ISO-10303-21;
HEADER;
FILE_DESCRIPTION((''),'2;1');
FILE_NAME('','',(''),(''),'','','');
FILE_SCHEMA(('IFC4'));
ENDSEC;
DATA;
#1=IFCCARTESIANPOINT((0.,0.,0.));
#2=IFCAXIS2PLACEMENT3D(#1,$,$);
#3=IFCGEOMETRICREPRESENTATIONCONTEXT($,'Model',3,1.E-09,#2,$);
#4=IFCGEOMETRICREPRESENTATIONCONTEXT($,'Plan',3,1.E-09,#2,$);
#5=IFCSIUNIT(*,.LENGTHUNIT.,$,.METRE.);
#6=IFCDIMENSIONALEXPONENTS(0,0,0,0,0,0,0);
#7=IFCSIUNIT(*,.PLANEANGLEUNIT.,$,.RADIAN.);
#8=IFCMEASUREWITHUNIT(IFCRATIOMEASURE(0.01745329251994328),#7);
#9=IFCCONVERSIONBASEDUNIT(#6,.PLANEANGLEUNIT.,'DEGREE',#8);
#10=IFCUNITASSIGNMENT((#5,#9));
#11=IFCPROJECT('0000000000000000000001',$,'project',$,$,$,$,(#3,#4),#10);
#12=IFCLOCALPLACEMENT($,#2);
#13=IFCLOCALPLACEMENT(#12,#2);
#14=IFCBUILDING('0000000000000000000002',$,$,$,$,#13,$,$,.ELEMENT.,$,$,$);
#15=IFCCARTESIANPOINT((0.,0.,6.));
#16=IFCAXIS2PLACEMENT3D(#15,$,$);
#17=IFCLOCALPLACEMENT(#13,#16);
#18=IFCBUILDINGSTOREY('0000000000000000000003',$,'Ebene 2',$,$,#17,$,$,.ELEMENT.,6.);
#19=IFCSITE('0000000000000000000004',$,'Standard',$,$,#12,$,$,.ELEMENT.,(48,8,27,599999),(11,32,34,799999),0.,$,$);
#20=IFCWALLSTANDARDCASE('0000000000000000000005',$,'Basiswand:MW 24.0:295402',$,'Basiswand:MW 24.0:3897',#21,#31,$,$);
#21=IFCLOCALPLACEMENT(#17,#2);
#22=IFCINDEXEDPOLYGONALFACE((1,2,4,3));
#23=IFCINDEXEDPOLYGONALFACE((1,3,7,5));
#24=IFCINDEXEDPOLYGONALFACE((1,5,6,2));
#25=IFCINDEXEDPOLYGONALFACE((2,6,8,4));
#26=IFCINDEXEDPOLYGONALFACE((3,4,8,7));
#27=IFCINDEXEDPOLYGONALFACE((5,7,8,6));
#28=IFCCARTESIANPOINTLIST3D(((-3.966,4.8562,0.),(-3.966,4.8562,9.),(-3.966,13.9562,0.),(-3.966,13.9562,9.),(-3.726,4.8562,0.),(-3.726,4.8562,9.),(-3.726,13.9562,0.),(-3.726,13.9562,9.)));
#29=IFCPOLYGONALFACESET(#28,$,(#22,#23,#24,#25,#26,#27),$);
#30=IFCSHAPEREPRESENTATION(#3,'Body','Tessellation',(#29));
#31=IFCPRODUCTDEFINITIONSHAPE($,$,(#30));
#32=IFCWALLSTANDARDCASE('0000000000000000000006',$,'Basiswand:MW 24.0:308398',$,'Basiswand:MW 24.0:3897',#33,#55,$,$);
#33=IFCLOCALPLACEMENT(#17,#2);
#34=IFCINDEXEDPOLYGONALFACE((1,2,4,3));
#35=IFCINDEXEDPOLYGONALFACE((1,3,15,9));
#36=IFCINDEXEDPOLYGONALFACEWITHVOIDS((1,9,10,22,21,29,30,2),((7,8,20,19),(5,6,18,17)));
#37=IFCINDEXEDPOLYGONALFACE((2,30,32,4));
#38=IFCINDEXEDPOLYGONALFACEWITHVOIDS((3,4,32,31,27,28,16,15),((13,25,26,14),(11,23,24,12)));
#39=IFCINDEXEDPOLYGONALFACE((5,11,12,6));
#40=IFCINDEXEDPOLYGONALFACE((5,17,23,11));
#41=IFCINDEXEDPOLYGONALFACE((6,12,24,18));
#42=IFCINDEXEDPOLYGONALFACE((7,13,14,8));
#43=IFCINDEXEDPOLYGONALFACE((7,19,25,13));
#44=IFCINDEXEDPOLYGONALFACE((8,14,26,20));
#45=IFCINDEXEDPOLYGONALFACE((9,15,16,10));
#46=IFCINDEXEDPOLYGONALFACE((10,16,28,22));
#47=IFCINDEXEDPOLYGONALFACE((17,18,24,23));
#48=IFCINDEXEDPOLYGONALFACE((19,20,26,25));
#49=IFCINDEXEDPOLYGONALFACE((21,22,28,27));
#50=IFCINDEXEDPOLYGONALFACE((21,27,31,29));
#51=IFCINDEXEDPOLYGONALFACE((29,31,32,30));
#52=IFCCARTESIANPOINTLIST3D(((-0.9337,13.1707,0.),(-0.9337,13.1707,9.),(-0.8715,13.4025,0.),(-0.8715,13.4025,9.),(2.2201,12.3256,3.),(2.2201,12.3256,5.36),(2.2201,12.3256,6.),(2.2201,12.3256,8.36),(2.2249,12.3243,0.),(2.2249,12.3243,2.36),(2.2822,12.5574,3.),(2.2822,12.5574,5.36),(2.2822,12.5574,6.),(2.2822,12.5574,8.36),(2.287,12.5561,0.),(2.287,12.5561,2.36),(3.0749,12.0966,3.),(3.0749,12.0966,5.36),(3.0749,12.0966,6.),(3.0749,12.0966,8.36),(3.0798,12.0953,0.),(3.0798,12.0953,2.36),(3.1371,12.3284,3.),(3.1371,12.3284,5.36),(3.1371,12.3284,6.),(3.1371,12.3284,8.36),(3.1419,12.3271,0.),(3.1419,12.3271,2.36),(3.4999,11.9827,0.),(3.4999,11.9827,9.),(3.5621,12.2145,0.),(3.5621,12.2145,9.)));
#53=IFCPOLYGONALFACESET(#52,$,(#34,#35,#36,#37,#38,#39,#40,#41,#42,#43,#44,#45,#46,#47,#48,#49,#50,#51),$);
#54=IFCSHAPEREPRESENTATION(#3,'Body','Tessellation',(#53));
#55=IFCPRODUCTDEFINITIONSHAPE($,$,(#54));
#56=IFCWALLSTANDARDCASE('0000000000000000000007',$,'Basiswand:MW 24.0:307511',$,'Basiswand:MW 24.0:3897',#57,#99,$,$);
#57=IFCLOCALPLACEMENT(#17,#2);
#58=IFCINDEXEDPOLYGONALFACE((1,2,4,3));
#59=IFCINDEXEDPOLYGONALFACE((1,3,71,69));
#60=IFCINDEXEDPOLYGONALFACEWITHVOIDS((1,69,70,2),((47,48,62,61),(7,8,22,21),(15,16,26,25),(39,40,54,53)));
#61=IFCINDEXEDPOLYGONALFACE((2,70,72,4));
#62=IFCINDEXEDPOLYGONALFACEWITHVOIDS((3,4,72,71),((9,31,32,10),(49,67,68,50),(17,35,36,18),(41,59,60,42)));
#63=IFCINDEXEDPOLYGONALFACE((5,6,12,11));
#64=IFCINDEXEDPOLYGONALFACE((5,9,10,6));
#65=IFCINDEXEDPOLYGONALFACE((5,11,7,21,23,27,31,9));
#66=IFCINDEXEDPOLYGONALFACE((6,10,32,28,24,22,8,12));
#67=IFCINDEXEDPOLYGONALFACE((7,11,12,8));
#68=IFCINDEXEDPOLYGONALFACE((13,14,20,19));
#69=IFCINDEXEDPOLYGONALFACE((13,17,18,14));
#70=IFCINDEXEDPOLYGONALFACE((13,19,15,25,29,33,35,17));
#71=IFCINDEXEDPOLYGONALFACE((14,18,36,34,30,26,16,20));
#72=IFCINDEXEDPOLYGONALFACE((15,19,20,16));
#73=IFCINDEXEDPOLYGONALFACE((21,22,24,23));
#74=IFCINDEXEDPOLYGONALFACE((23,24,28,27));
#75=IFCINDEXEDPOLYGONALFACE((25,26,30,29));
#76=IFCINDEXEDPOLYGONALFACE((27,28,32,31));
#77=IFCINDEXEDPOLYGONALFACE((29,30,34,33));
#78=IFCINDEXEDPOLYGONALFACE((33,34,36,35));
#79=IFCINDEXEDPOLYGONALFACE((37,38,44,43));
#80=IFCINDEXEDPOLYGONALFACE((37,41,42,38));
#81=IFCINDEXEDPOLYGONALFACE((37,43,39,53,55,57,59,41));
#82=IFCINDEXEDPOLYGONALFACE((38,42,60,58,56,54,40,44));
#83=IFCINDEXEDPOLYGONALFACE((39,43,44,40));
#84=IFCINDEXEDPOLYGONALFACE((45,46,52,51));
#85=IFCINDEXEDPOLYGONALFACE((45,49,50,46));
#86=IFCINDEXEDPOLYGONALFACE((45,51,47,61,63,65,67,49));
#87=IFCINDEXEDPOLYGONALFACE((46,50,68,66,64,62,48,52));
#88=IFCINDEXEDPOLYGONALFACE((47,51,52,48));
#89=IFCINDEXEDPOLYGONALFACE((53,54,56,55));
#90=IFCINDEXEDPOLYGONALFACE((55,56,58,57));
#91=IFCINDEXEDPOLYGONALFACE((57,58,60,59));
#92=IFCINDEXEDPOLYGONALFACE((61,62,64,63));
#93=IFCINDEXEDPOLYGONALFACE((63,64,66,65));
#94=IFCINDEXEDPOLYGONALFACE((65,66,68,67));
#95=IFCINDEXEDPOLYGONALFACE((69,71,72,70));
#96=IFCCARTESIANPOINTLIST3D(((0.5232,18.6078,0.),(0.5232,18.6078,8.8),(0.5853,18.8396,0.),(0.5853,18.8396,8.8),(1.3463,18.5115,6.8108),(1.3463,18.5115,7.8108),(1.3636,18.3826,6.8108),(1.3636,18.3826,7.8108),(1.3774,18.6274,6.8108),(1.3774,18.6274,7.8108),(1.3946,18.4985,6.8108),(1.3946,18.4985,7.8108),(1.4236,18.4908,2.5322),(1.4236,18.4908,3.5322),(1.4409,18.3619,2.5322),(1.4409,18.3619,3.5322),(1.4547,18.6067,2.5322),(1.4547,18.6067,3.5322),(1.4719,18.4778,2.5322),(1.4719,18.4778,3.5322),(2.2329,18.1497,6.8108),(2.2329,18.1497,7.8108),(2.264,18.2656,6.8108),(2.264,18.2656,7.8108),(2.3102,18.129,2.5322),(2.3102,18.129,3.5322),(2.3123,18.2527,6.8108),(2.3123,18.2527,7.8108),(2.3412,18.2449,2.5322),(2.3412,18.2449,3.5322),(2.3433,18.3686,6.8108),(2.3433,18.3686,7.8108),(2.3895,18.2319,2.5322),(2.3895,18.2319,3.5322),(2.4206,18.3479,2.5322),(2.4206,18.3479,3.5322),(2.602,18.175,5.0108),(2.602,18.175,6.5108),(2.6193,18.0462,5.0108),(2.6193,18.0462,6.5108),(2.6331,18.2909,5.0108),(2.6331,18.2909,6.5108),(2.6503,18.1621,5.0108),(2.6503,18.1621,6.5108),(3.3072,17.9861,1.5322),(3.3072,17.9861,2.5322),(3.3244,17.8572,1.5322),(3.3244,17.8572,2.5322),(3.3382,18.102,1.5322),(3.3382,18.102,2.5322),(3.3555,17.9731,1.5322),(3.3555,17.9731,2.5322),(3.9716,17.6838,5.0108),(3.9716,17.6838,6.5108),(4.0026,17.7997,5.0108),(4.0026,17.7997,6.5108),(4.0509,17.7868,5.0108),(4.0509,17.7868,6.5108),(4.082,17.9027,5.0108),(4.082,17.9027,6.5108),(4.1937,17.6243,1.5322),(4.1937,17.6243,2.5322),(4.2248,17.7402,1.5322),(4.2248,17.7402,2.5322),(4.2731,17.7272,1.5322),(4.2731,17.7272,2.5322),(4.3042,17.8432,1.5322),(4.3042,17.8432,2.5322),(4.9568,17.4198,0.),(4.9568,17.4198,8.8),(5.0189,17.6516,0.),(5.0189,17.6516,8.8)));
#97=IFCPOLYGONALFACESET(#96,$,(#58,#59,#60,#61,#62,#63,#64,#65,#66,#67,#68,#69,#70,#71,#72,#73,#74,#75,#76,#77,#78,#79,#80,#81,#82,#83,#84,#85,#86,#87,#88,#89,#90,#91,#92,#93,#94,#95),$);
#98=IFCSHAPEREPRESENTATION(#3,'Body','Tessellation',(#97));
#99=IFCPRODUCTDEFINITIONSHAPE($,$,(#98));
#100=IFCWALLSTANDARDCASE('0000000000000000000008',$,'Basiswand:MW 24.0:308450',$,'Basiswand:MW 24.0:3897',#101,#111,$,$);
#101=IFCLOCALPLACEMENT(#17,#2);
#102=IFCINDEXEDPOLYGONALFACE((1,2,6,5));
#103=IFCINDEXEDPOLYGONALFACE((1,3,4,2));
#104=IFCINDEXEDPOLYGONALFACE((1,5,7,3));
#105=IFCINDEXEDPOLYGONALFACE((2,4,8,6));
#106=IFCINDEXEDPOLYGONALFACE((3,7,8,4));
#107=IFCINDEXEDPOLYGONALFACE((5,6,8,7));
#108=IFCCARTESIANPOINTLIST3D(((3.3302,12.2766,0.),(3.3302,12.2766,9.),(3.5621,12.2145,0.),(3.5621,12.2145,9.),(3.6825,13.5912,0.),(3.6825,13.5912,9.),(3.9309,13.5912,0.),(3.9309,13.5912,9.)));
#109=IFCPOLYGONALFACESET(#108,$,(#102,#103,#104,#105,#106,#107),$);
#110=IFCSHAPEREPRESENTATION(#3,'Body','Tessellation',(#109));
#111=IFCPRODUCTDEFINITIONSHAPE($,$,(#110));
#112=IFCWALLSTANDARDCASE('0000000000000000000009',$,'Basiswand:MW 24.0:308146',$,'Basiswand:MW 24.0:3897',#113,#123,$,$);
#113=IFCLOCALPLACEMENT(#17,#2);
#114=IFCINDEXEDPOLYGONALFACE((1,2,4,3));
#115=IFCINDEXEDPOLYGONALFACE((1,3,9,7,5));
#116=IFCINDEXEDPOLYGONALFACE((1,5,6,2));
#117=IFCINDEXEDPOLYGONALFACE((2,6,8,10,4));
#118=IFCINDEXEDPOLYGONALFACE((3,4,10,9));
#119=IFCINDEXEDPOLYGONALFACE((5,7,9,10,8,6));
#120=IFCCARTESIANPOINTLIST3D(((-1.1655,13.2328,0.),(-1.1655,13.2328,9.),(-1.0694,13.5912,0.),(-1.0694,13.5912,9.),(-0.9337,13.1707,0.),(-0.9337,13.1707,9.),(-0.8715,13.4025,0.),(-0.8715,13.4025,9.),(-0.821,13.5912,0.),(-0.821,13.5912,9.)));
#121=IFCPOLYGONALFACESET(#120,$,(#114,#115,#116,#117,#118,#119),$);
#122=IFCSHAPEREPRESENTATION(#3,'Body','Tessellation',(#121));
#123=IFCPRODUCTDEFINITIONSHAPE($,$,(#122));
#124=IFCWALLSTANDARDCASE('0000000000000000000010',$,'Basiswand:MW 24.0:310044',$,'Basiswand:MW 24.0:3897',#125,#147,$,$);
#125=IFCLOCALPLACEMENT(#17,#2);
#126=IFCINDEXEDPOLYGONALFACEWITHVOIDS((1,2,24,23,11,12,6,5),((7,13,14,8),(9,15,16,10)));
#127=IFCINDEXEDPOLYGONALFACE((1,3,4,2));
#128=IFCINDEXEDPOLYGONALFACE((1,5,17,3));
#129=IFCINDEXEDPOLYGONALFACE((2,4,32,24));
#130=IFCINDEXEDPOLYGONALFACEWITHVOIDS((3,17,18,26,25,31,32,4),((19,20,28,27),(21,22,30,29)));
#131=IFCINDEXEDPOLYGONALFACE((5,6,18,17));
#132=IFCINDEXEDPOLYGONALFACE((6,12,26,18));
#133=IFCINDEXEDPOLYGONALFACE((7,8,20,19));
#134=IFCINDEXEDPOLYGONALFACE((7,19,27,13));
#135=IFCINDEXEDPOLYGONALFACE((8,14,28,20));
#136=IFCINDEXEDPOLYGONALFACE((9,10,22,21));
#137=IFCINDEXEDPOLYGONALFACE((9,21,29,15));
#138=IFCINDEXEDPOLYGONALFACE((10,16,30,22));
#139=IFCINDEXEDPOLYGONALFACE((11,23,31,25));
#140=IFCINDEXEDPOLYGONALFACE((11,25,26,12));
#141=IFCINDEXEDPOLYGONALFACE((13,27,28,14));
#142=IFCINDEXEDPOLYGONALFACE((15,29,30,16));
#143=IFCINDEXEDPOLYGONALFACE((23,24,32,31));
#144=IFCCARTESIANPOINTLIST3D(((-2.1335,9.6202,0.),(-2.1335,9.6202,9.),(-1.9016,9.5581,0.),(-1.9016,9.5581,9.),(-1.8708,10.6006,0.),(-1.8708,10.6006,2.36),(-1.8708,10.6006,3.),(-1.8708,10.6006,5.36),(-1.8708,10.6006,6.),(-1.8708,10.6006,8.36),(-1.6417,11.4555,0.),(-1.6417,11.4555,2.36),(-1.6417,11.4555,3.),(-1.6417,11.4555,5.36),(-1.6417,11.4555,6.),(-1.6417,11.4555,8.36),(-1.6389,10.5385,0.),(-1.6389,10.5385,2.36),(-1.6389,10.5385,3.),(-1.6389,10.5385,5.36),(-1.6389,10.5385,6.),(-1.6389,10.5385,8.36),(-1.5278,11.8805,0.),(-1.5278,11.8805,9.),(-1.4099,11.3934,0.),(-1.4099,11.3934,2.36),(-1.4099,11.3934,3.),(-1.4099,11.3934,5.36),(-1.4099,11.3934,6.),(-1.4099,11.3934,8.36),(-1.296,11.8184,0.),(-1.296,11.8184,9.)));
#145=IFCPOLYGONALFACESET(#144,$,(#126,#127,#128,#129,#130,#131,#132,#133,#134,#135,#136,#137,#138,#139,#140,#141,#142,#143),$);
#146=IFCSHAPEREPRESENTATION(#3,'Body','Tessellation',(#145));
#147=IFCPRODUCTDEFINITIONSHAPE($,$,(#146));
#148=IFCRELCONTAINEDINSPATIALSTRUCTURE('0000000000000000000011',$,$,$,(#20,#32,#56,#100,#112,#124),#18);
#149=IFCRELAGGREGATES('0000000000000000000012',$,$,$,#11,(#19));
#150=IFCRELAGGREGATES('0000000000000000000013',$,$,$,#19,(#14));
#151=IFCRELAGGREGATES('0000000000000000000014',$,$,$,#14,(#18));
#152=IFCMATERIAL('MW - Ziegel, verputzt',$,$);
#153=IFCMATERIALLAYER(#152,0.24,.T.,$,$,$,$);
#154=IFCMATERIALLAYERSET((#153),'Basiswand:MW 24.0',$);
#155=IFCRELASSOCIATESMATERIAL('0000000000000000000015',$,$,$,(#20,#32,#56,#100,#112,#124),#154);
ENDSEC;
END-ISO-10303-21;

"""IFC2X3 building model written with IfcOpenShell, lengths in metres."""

from ifc_helpers import new_model, entity, si_unit, converted_unit, frame, frame_2d, origin, place, context, project, spatial, polyline, rectangle, outline, extrude, clip, bounded_halfspace, material, layer, layer_set, layer_usage, element, save


model = new_model("IFC2X3")

# Units and contexts
model_context = context("Model", 3, precision=1e-09, world=origin())
plan_context = context("Plan", 3, precision=1e-09, world=origin())
ifc_project = project(units=[si_unit("LENGTHUNIT", "METRE"), converted_unit("PLANEANGLEUNIT", "DEGREE", entity("IfcRatioMeasure", 0.01745329251994328), si_unit("PLANEANGLEUNIT", "RADIAN"), dimensions=[0, 0, 0, 0, 0, 0, 0])], contexts=[model_context, plan_context])

# Site, building, storey
site_placement = place(None, origin())
site = spatial("IfcSite", under=ifc_project, at=site_placement, Name="Standard", CompositionType="ELEMENT", RefLatitude=(48, 8, 27, 599999), RefLongitude=(11, 32, 34, 799999), RefElevation=0.0)
building_placement = place(site_placement, origin())
building = spatial("IfcBuilding", under=site, at=building_placement, CompositionType="ELEMENT")
storey_placement = place(building_placement, frame((0.0, 0.0, 6.0)))
storey = spatial("IfcBuildingStorey", under=building, at=storey_placement, Name="Ebene 2", CompositionType="ELEMENT", Elevation=6.0)

# Wall
ifc_material = material(Name="MW - Ziegel, verputzt")
ifc_layer_1 = layer(ifc_material, 0.24, ventilated=True)
ifc_layer_set_1 = layer_set([ifc_layer_1], Name="Basiswand:MW 24.0")
ifc_layer_usage_1 = layer_usage(ifc_layer_set_1, "AXIS2", "NEGATIVE", 0.12)
wall_1_placement = place(storey_placement, frame((-3.846, 13.9562, 0.0), z_axis=(0.0, 0.0, 1.0), x_axis=(0.0, -1.0, 0.0)))
element("IfcWallStandardCase", 1, at=wall_1_placement, inside=storey, material=ifc_layer_usage_1, Name="Basiswand:MW 24.0:295402", ObjectType="Basiswand:MW 24.0:3897", context=model_context, shape_type="SweptSolid", body=[
    extrude(rectangle(XDim=9.1, YDim=0.24, at=frame_2d((4.55, 0.0), x_axis=(-1.0, 0.0))), origin(), (0.0, 0.0, 1.0), 9.0),
])

# Walls, openings
ifc_layer_usage_2 = layer_usage(ifc_layer_set_1, "AXIS2", "NEGATIVE", 0.12)
wall_2_placement = place(storey_placement, frame((-0.9026, 13.2866, 0.0), z_axis=(0.0, 0.0, 1.0), x_axis=(0.965926, -0.258819, 0.0)))
wall_2 = element("IfcWallStandardCase", 2, at=wall_2_placement, inside=storey, material=ifc_layer_usage_2, Name="Basiswand:MW 24.0:308398", ObjectType="Basiswand:MW 24.0:3897", context=model_context, shape_type="SweptSolid", body=[
    extrude(rectangle(XDim=4.59, YDim=0.24, at=frame_2d((2.295, 0.0), x_axis=(-1.0, 0.0))), origin(), (0.0, 0.0, 1.0), 9.0),
])
opening_1_placement = place(wall_2_placement, frame((3.27, -0.12, 0.0)))
element("IfcOpeningElement", 3, at=opening_1_placement, cuts=wall_2, ObjectType="Opening", context=model_context, shape_type="SweptSolid", body=[
    extrude(rectangle(XDim=2.36, YDim=0.885, at=frame_2d((1.18, 0.4425), x_axis=(1.0, 0.0))), frame((0.0, 0.0, 0.0), z_axis=(0.0, 1.0, 0.0), x_axis=(0.0, 0.0, 1.0)), (0.0, 0.0, 1.0), 0.24),
])
opening_2_placement = place(wall_2_placement, frame((3.265, -0.12, 6.0)))
element("IfcOpeningElement", 4, at=opening_2_placement, cuts=wall_2, ObjectType="Opening", context=model_context, shape_type="SweptSolid", body=[
    extrude(rectangle(XDim=2.36, YDim=0.885, at=frame_2d((1.18, 0.4425), x_axis=(1.0, 0.0))), frame((0.0, 0.0, 0.0), z_axis=(0.0, 1.0, 0.0), x_axis=(0.0, 0.0, 1.0)), (0.0, 0.0, 1.0), 0.24),
])
opening_3_placement = place(wall_2_placement, frame((3.265, -0.12, 3.0)))
element("IfcOpeningElement", 5, at=opening_3_placement, cuts=wall_2, ObjectType="Opening", context=model_context, shape_type="SweptSolid", body=[
    extrude(rectangle(XDim=2.36, YDim=0.885, at=frame_2d((1.18, 0.4425), x_axis=(1.0, 0.0))), frame((0.0, 0.0, 0.0), z_axis=(0.0, 1.0, 0.0), x_axis=(0.0, 0.0, 1.0)), (0.0, 0.0, 1.0), 0.24),
])
ifc_layer_usage_3 = layer_usage(ifc_layer_set_1, "AXIS2", "NEGATIVE", 0.12)
wall_3_placement = place(storey_placement, frame((0.5543, 18.7237, 0.0), z_axis=(0.0, 0.0, 1.0), x_axis=(0.965926, -0.258819, 0.0)))
wall_3 = element("IfcWallStandardCase", 6, at=wall_3_placement, inside=storey, material=ifc_layer_usage_3, Name="Basiswand:MW 24.0:307511", ObjectType="Basiswand:MW 24.0:3897", context=model_context, shape_type="Clipping", body=[
    clip(extrude(rectangle(XDim=4.59, YDim=0.24, at=frame_2d((2.295, 0.0), x_axis=(-1.0, 0.0))), origin(), (0.0, 0.0, 1.0), 8.8), bounded_halfspace(frame((0.0, -0.12, 8.8), z_axis=(0.0, 0.0, -1.0), x_axis=(1.0, 0.0, 0.0)), True, frame((0.0, -0.12, 8.8)), polyline([(0.0, 0.0), (4.35, 0.0), (4.59, 0.0), (4.59, 0.1498), (0.0, 0.1498), (0.0, 0.0)]))),
])
opening_4_placement = place(wall_3_placement, origin())
element("IfcOpeningElement", 7, at=opening_4_placement, cuts=wall_3, ObjectType="Opening", context=model_context, shape_type="SweptSolid", body=[
    extrude(outline(polyline([(-0.45, -0.28), (0.45, -0.28), (0.45, -0.03), (0.5, -0.03), (0.5, 0.34), (-0.5, 0.34), (-0.5, -0.03), (-0.45, -0.03), (-0.45, -0.28)])), frame((3.35, 0.03, 1.5322)), (0.0, 0.0, 1.0), 1.0),
])
opening_5_placement = place(wall_3_placement, origin())
element("IfcOpeningElement", 8, at=opening_5_placement, cuts=wall_3, ObjectType="Opening", context=model_context, shape_type="SweptSolid", body=[
    extrude(outline(polyline([(-0.45, -0.28), (0.45, -0.28), (0.45, -0.03), (0.5, -0.03), (0.5, 0.34), (-0.5, 0.34), (-0.5, -0.03), (-0.45, -0.03), (-0.45, -0.28)])), frame((1.32, 0.03, 6.8108)), (0.0, 0.0, 1.0), 1.0),
])
opening_6_placement = place(wall_3_placement, origin())
element("IfcOpeningElement", 9, at=opening_6_placement, cuts=wall_3, ObjectType="Opening", context=model_context, shape_type="SweptSolid", body=[
    extrude(outline(polyline([(-0.7, -0.28), (0.7, -0.28), (0.7, -0.03), (0.75, -0.03), (0.75, 0.34), (-0.75, 0.34), (-0.75, -0.03), (-0.7, -0.03), (-0.7, -0.28)])), frame((2.87, 0.03, 5.0108)), (0.0, 0.0, 1.0), 1.5),
])
opening_7_placement = place(wall_3_placement, origin())
element("IfcOpeningElement", 10, at=opening_7_placement, cuts=wall_3, ObjectType="Opening", context=model_context, shape_type="SweptSolid", body=[
    extrude(outline(polyline([(-0.45, -0.28), (0.45, -0.28), (0.45, -0.03), (0.5, -0.03), (0.5, 0.34), (-0.5, 0.34), (-0.5, -0.03), (-0.45, -0.03), (-0.45, -0.28)])), frame((1.4, 0.03, 2.5322)), (0.0, 0.0, 1.0), 1.0),
])

# Walls
ifc_layer_usage_4 = layer_usage(ifc_layer_set_1, "AXIS2", "NEGATIVE", 0.12)
wall_4_placement = place(storey_placement, frame((3.4462, 12.2456, 0.0), z_axis=(0.0, 0.0, 1.0), x_axis=(0.258819, 0.965926, 0.0)))
element("IfcWallStandardCase", 11, at=wall_4_placement, inside=storey, material=ifc_layer_usage_4, Name="Basiswand:MW 24.0:308450", ObjectType="Basiswand:MW 24.0:3897", context=model_context, shape_type="SweptSolid", body=[
    extrude(outline(polyline([(1.4253, -0.12), (1.3609, 0.12), (0.0, 0.12), (0.0, -0.12), (1.4253, -0.12)])), origin(), (0.0, 0.0, 1.0), 9.0),
])
ifc_layer_usage_5 = layer_usage(ifc_layer_set_1, "AXIS2", "NEGATIVE", 0.12)
wall_5_placement = place(storey_placement, frame((-0.9369, 13.6222, 0.0), z_axis=(0.0, 0.0, 1.0), x_axis=(-0.258819, -0.965926, 0.0)))
element("IfcWallStandardCase", 12, at=wall_5_placement, inside=storey, material=ifc_layer_usage_5, Name="Basiswand:MW 24.0:308146", ObjectType="Basiswand:MW 24.0:3897", context=model_context, shape_type="SweptSolid", body=[
    extrude(outline(polyline([(0.4354, -0.12), (0.4354, 0.12), (0.1954, 0.12), (0.0, 0.12), (0.0643, -0.12), (0.4354, -0.12)])), origin(), (0.0, 0.0, 1.0), 9.0),
])

# Wall, openings
ifc_layer_usage_6 = layer_usage(ifc_layer_set_1, "AXIS2", "NEGATIVE", 0.12)
wall_6_placement = place(storey_placement, frame((-1.4119, 11.8494, 0.0), z_axis=(0.0, 0.0, 1.0), x_axis=(-0.258819, -0.965926, 0.0)))
wall_6 = element("IfcWallStandardCase", 13, at=wall_6_placement, inside=storey, material=ifc_layer_usage_6, Name="Basiswand:MW 24.0:310044", ObjectType="Basiswand:MW 24.0:3897", context=model_context, shape_type="SweptSolid", body=[
    extrude(rectangle(XDim=2.34, YDim=0.24, at=frame_2d((1.17, 0.0), x_axis=(-1.0, 0.0))), origin(), (0.0, 0.0, 1.0), 9.0),
])
opening_8_placement = place(wall_6_placement, frame((0.44, -0.12, 0.0)))
element("IfcOpeningElement", 14, at=opening_8_placement, cuts=wall_6, ObjectType="Opening", context=model_context, shape_type="SweptSolid", body=[
    extrude(rectangle(XDim=2.36, YDim=0.885, at=frame_2d((1.18, 0.4425), x_axis=(1.0, 0.0))), frame((0.0, 0.0, 0.0), z_axis=(0.0, 1.0, 0.0), x_axis=(0.0, 0.0, 1.0)), (0.0, 0.0, 1.0), 0.24),
])
opening_9_placement = place(wall_6_placement, frame((0.44, -0.12, 6.0)))
element("IfcOpeningElement", 15, at=opening_9_placement, cuts=wall_6, ObjectType="Opening", context=model_context, shape_type="SweptSolid", body=[
    extrude(rectangle(XDim=2.36, YDim=0.885, at=frame_2d((1.18, 0.4425), x_axis=(1.0, 0.0))), frame((0.0, 0.0, 0.0), z_axis=(0.0, 1.0, 0.0), x_axis=(0.0, 0.0, 1.0)), (0.0, 0.0, 1.0), 0.24),
])
opening_10_placement = place(wall_6_placement, frame((0.44, -0.12, 3.0)))
element("IfcOpeningElement", 16, at=opening_10_placement, cuts=wall_6, ObjectType="Opening", context=model_context, shape_type="SweptSolid", body=[
    extrude(rectangle(XDim=2.36, YDim=0.885, at=frame_2d((1.18, 0.4425), x_axis=(1.0, 0.0))), frame((0.0, 0.0, 0.0), z_axis=(0.0, 1.0, 0.0), x_axis=(0.0, 0.0, 1.0)), (0.0, 0.0, 1.0), 0.24),
])

save(model, "model.ifc")
